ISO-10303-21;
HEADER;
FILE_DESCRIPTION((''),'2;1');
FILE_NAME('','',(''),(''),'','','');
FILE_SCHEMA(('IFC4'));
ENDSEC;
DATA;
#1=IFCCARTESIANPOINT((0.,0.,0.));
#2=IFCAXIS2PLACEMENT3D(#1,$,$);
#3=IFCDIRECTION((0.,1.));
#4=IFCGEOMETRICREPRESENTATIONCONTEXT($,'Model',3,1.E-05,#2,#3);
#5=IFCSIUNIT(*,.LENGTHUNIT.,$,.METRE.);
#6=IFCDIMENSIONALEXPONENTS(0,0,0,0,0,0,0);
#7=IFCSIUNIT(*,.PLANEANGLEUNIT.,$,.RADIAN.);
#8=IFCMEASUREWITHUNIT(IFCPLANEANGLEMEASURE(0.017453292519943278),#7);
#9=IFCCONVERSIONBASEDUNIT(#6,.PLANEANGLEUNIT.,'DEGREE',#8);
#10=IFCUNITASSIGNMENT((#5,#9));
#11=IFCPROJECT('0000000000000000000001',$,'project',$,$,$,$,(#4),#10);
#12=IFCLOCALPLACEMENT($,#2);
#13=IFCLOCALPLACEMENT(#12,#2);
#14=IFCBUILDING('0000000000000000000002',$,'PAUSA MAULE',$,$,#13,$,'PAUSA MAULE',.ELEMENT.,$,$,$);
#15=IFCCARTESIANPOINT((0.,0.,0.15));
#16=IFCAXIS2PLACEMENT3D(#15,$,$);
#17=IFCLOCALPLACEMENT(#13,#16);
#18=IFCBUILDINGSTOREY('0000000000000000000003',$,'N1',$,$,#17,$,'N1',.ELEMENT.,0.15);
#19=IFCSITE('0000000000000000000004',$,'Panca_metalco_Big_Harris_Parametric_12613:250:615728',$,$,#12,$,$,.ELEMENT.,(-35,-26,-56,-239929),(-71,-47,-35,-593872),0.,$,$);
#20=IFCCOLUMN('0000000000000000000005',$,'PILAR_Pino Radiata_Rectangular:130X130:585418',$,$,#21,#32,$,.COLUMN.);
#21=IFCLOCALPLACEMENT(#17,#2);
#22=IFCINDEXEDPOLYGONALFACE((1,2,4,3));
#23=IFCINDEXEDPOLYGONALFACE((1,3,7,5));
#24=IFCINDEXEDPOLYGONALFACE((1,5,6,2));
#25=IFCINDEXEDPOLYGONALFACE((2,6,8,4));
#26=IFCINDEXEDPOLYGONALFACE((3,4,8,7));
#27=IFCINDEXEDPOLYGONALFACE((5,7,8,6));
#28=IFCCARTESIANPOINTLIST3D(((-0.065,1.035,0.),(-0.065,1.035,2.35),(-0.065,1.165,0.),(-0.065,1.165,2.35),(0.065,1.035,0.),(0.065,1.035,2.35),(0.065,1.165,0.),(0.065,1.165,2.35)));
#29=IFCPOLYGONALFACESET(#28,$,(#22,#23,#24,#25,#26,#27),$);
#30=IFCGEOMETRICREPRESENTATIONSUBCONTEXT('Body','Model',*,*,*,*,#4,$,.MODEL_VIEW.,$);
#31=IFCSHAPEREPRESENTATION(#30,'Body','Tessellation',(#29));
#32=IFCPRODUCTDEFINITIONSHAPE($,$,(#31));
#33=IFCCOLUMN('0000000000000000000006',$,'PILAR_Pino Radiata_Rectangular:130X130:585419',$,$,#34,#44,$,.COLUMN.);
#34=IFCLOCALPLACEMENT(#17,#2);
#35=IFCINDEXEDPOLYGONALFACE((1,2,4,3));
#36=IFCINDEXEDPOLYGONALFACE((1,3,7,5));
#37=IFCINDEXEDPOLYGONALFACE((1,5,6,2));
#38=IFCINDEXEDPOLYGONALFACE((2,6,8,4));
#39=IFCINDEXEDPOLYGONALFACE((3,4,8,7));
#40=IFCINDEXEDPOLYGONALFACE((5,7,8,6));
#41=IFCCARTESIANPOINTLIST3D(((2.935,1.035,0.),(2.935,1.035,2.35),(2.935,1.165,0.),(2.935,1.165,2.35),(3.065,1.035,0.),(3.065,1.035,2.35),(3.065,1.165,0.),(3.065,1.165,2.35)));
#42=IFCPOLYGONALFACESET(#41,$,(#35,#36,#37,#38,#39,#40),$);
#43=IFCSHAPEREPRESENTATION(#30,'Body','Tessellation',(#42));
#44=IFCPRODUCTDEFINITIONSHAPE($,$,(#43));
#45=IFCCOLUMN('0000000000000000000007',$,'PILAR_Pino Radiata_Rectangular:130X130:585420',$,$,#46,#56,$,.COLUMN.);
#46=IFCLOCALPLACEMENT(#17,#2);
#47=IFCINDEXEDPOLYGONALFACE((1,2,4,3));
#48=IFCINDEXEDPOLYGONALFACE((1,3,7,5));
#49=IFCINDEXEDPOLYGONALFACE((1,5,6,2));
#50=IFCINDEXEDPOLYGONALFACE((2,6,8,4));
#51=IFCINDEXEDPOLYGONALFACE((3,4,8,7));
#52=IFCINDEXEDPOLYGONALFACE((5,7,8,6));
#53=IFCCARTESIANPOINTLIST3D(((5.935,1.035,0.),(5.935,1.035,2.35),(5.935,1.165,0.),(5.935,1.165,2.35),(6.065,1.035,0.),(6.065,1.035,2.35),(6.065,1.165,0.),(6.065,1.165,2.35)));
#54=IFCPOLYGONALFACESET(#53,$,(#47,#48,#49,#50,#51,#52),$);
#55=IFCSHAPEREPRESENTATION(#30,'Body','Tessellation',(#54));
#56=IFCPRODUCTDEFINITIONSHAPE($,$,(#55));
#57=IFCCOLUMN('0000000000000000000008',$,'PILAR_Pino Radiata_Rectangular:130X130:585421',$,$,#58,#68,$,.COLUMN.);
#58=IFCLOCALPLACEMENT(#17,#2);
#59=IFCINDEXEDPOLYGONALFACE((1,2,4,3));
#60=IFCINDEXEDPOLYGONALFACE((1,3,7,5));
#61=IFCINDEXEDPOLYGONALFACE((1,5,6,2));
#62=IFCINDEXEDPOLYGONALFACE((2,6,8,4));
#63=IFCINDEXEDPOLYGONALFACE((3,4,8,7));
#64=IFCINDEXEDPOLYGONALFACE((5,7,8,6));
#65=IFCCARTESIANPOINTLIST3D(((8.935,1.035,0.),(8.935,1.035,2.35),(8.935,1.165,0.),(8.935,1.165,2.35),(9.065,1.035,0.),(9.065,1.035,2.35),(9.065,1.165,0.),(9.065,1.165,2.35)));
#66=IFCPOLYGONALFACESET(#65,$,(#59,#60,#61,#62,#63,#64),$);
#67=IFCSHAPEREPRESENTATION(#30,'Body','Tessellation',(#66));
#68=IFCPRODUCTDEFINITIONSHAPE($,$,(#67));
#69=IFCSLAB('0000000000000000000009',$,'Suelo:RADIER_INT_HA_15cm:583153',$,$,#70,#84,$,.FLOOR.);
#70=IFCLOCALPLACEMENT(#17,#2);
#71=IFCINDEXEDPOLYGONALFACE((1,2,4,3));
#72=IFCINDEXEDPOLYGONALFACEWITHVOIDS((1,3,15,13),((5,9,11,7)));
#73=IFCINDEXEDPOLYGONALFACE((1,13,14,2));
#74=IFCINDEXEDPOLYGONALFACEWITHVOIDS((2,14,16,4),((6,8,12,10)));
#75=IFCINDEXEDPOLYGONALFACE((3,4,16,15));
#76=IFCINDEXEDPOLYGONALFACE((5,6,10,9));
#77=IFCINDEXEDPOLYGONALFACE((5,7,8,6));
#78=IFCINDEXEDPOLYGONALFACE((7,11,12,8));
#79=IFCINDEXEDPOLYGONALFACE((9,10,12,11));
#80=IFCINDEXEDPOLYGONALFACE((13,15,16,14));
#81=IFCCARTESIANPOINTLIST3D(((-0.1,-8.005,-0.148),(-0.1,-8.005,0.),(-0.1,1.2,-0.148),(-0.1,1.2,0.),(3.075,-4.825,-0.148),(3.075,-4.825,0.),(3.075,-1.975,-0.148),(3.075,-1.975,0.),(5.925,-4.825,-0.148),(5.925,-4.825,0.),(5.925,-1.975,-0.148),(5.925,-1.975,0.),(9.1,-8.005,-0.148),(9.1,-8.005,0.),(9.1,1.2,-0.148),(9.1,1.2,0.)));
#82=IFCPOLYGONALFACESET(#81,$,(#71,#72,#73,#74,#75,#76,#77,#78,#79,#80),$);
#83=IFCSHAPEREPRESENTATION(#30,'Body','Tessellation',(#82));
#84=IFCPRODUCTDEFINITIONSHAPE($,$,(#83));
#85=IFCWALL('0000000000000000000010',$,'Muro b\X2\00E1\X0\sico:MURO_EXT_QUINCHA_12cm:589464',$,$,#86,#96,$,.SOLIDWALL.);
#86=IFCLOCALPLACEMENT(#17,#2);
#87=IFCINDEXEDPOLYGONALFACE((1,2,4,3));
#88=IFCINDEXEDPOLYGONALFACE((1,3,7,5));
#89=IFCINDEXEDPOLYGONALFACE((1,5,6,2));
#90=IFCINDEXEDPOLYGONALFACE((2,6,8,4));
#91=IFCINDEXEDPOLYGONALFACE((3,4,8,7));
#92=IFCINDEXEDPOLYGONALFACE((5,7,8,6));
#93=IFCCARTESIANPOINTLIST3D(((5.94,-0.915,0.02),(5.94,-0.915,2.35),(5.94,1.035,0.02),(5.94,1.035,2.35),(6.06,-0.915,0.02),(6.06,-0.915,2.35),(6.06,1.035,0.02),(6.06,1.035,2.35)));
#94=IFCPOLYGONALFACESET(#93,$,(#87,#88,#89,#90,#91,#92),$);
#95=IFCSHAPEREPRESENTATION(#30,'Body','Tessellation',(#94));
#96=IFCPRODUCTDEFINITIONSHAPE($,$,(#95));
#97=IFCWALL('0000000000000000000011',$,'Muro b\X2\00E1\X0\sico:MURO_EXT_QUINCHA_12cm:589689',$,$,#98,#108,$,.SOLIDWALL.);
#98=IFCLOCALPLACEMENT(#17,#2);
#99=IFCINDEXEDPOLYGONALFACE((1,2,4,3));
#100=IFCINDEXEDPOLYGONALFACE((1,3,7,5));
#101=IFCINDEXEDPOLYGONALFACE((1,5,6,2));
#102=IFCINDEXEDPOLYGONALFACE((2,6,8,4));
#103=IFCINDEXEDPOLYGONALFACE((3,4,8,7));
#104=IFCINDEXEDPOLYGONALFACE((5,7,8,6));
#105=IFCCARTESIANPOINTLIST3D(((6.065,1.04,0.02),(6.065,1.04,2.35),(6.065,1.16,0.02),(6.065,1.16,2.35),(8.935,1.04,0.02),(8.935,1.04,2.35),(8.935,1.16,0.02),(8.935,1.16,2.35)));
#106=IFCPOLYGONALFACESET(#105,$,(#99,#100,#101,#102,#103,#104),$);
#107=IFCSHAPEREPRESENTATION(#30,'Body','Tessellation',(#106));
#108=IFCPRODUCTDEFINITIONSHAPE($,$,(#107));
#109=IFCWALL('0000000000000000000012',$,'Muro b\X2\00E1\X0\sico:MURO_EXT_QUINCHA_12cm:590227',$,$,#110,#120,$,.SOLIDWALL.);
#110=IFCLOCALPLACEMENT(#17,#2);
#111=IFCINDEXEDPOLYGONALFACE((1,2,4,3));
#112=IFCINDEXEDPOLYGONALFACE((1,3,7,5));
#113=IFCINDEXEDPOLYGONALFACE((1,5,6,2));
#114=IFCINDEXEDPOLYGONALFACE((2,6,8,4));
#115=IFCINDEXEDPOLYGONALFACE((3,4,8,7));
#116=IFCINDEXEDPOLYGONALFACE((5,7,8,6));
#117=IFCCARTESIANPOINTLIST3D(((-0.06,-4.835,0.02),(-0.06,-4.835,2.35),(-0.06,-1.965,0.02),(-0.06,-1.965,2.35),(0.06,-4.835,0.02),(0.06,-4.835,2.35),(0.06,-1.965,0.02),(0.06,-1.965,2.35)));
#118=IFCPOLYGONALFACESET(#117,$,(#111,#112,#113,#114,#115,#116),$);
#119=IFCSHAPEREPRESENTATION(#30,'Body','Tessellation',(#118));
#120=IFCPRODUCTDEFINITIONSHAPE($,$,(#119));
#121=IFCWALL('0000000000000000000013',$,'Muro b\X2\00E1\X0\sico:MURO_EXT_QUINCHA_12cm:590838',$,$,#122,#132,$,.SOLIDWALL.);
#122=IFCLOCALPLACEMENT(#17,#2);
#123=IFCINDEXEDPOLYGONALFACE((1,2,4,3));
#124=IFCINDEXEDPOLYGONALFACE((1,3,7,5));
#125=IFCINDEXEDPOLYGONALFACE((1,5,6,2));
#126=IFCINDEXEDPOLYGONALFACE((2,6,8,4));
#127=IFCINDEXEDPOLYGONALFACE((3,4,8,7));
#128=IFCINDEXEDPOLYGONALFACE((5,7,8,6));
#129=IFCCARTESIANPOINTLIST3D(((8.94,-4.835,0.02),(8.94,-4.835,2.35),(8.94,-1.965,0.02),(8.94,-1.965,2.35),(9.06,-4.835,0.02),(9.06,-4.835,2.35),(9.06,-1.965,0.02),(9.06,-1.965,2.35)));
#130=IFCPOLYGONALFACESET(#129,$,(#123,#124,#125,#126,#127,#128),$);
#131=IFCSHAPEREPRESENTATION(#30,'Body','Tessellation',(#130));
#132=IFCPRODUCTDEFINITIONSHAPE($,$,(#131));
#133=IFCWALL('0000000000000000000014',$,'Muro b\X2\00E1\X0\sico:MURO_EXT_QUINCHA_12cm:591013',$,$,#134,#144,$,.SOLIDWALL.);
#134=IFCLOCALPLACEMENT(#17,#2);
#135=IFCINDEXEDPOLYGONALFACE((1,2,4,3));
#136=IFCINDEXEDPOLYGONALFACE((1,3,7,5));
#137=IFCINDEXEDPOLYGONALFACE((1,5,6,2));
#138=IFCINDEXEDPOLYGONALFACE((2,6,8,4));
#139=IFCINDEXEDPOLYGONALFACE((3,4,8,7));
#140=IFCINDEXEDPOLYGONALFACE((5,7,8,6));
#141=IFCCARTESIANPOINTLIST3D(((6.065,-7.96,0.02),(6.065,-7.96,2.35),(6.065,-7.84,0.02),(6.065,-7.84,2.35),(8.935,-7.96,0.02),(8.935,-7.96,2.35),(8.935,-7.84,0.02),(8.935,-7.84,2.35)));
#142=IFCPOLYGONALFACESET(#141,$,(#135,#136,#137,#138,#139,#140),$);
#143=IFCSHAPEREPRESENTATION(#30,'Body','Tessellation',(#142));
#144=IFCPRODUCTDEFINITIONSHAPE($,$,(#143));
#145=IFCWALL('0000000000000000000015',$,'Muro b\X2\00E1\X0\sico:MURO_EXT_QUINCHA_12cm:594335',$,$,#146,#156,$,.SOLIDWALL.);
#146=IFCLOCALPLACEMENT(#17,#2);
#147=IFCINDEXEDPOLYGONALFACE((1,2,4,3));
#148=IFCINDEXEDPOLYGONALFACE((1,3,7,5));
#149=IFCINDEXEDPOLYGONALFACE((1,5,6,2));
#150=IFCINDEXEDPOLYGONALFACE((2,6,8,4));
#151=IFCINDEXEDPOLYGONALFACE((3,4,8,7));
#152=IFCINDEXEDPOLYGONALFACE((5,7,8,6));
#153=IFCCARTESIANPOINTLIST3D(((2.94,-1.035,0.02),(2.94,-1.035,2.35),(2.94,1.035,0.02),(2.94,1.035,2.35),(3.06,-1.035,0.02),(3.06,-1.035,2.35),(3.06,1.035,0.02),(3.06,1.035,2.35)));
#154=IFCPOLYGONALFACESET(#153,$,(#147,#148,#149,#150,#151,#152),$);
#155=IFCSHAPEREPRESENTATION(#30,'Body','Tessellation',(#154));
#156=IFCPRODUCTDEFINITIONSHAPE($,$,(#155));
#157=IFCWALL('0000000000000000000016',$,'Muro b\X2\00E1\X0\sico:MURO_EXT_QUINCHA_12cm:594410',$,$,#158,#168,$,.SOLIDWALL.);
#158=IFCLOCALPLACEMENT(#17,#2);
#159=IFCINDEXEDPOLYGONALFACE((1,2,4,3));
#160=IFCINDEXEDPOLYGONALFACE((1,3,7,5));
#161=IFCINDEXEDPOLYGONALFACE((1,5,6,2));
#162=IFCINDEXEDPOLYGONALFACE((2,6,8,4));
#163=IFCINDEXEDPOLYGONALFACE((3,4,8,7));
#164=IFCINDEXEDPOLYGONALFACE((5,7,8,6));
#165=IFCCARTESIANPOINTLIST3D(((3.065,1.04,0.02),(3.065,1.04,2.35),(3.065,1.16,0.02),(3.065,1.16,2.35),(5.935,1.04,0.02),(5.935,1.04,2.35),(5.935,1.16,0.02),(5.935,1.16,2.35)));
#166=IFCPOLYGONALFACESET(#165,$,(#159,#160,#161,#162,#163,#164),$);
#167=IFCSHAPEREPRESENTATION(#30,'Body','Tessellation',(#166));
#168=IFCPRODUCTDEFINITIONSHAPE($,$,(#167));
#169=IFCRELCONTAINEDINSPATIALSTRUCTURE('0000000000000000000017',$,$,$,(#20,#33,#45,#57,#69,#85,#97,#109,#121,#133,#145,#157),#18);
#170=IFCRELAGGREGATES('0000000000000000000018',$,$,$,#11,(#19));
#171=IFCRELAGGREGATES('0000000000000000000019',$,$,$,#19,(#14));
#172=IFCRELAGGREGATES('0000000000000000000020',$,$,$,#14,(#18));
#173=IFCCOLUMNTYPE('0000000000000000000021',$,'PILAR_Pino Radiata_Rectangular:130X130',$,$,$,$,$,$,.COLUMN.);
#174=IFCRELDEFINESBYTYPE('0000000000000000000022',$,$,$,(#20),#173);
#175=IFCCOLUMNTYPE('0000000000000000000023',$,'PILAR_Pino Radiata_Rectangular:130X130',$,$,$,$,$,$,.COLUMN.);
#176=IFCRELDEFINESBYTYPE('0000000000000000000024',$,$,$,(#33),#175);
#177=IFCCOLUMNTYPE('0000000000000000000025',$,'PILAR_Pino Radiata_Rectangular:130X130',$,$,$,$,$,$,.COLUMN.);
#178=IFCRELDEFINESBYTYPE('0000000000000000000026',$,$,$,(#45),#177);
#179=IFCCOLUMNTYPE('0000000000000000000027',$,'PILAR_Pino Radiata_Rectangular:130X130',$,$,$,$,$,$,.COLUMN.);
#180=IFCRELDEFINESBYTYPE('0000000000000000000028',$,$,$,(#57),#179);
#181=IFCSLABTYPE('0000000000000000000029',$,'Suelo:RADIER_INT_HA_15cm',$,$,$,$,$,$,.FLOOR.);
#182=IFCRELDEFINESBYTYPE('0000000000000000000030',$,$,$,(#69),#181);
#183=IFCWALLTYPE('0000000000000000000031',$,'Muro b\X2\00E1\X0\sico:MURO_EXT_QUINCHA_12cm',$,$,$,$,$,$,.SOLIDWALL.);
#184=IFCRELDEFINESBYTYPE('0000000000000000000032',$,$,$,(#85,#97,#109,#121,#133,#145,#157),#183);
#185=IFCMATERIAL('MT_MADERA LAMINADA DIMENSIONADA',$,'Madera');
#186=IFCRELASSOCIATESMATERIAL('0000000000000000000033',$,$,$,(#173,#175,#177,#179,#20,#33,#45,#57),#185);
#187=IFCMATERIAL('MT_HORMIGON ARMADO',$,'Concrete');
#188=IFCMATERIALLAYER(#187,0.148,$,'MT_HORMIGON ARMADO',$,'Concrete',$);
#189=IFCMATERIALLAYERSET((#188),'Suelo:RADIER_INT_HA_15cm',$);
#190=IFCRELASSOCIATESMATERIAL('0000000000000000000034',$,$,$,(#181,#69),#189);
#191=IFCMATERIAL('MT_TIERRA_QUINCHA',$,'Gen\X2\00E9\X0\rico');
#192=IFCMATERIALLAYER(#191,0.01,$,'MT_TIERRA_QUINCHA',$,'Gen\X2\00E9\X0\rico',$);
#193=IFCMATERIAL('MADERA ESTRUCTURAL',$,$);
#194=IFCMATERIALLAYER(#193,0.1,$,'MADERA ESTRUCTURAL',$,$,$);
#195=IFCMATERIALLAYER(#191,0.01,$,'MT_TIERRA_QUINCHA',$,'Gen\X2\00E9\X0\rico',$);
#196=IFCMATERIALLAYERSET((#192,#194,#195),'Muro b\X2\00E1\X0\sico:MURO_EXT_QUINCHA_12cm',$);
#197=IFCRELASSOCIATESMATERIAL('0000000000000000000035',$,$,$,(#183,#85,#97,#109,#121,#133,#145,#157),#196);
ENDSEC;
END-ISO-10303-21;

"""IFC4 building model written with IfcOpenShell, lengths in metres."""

from ifc_helpers import new_model, entity, si_unit, converted_unit, direction, frame, frame_2d, origin, origin_2d_with_axis, place, context, subcontext, project, spatial, rectangle, extrude, boolean, source, transform, mapped, material, layer, layer_set, layer_usage, material_profile, profile_set, profile_usage, type_object, type_shapes, element, save


model = new_model("IFC4")

# Units and contexts
model_context = context("Model", 3, precision=1e-05, world=origin(), true_north=direction((0.0, 1.0)))
body_context = subcontext(model_context, "Body", "Model", "MODEL_VIEW")
ifc_project = project(units=[si_unit("LENGTHUNIT", "METRE"), converted_unit("PLANEANGLEUNIT", "DEGREE", entity("IfcPlaneAngleMeasure", 0.017453292519943278), si_unit("PLANEANGLEUNIT", "RADIAN"), dimensions=[0, 0, 0, 0, 0, 0, 0])], contexts=[model_context])

# Site, building, storey
site_placement = place(None, origin())
site = spatial("IfcSite", under=ifc_project, at=site_placement, Name="Panca_metalco_Big_Harris_Parametric_12613:250:615728", CompositionType="ELEMENT", RefLatitude=(-35, -26, -56, -239929), RefLongitude=(-71, -47, -35, -593872), RefElevation=0.0)
building_placement = place(site_placement, origin())
building = spatial("IfcBuilding", under=site, at=building_placement, Name="PAUSA MAULE", LongName="PAUSA MAULE", CompositionType="ELEMENT")
storey_placement = place(building_placement, frame((0.0, 0.0, 0.15)))
storey = spatial("IfcBuildingStorey", under=building, at=storey_placement, Name="N1", LongName="N1", CompositionType="ELEMENT", Elevation=0.15)

# Columns
ifc_material_1 = material(Name="MT_MADERA LAMINADA DIMENSIONADA", Category="Madera")
ifc_material_profile = material_profile(ifc_material_1, rectangle(XDim=0.13, YDim=0.13, at=frame_2d((0.0, 0.0), x_axis=(1.0, 0.0))), Name="130X130")
ifc_profile_set = profile_set([ifc_material_profile], Name="130X130")
ifc_profile_usage = profile_usage(ifc_profile_set)
column_type_1 = type_object("IfcColumnType", Name="PILAR_Pino Radiata_Rectangular:130X130", PredefinedType="COLUMN", material=ifc_profile_set)
shared_shape_1 = source(origin(), body_context, "Body", "SweptSolid", [
    extrude(rectangle(XDim=0.13, YDim=0.13, at=origin_2d_with_axis()), frame((0.0, 1.1, 0.15)), (0.0, 0.0, 1.0), 2.35),
])
type_shapes(column_type_1, [shared_shape_1])
column_1_placement = place(storey_placement, frame((0.0, 0.0, -0.15)))
element("IfcColumn", 1, at=column_1_placement, inside=storey, type_object=column_type_1, material=ifc_profile_usage, Name="PILAR_Pino Radiata_Rectangular:130X130:585418", PredefinedType="COLUMN", context=body_context, shape_type="MappedRepresentation", body=[
    mapped(shared_shape_1, transform((0.0, 0.0, 0.0), scale=1.0)),
])
column_type_2 = type_object("IfcColumnType", Name="PILAR_Pino Radiata_Rectangular:130X130", PredefinedType="COLUMN", material=ifc_profile_set)
shared_shape_2 = source(origin(), body_context, "Body", "SweptSolid", [
    extrude(rectangle(XDim=0.13, YDim=0.13, at=origin_2d_with_axis()), frame((3.0, 1.1, 0.15)), (0.0, 0.0, 1.0), 2.35),
])
type_shapes(column_type_2, [shared_shape_2])
column_2_placement = place(storey_placement, frame((0.0, 0.0, -0.15)))
element("IfcColumn", 2, at=column_2_placement, inside=storey, type_object=column_type_2, material=ifc_profile_usage, Name="PILAR_Pino Radiata_Rectangular:130X130:585419", PredefinedType="COLUMN", context=body_context, shape_type="MappedRepresentation", body=[
    mapped(shared_shape_2, transform((0.0, 0.0, 0.0), scale=1.0)),
])
column_type_3 = type_object("IfcColumnType", Name="PILAR_Pino Radiata_Rectangular:130X130", PredefinedType="COLUMN", material=ifc_profile_set)
shared_shape_3 = source(origin(), body_context, "Body", "SweptSolid", [
    extrude(rectangle(XDim=0.13, YDim=0.13, at=frame_2d((0.0, 0.0), x_axis=(1.0, 0.0))), frame((6.0, 1.1, 0.15)), (0.0, 0.0, 1.0), 2.35),
])
type_shapes(column_type_3, [shared_shape_3])
column_3_placement = place(storey_placement, frame((0.0, 0.0, -0.15)))
element("IfcColumn", 3, at=column_3_placement, inside=storey, type_object=column_type_3, material=ifc_profile_usage, Name="PILAR_Pino Radiata_Rectangular:130X130:585420", PredefinedType="COLUMN", context=body_context, shape_type="MappedRepresentation", body=[
    mapped(shared_shape_3, transform((0.0, 0.0, 0.0), scale=1.0)),
])
column_type_4 = type_object("IfcColumnType", Name="PILAR_Pino Radiata_Rectangular:130X130", PredefinedType="COLUMN", material=ifc_profile_set)
shared_shape_4 = source(origin(), body_context, "Body", "SweptSolid", [
    extrude(rectangle(XDim=0.13, YDim=0.13, at=frame_2d((0.0, 0.0), x_axis=(1.0, 0.0))), frame((9.0, 1.1, 0.15)), (0.0, 0.0, 1.0), 2.35),
])
type_shapes(column_type_4, [shared_shape_4])
column_4_placement = place(storey_placement, frame((0.0, 0.0, -0.15)))
element("IfcColumn", 4, at=column_4_placement, inside=storey, type_object=column_type_4, material=ifc_profile_usage, Name="PILAR_Pino Radiata_Rectangular:130X130:585421", PredefinedType="COLUMN", context=body_context, shape_type="MappedRepresentation", body=[
    mapped(shared_shape_4, transform((0.0, 0.0, 0.0), scale=1.0)),
])

# Slab, opening
ifc_material_2 = material(Name="MT_HORMIGON ARMADO", Category="Concrete")
ifc_layer_1 = layer(ifc_material_2, 0.148, Name="MT_HORMIGON ARMADO", Category="Concrete")
ifc_layer_set_1 = layer_set([ifc_layer_1], Name="Suelo:RADIER_INT_HA_15cm")
ifc_layer_usage_1 = layer_usage(ifc_layer_set_1, "AXIS3", "POSITIVE", 0.0)
slab_type = type_object("IfcSlabType", Name="Suelo:RADIER_INT_HA_15cm", PredefinedType="FLOOR", material=ifc_layer_set_1)
slab_placement = place(storey_placement, origin())
slab = element("IfcSlab", 5, at=slab_placement, inside=storey, type_object=slab_type, material=ifc_layer_usage_1, Name="Suelo:RADIER_INT_HA_15cm:583153", PredefinedType="FLOOR", context=body_context, shape_type="CSG", body=[
    boolean("DIFFERENCE", extrude(rectangle(XDim=9.205, YDim=9.2, at=frame_2d((0.0, 0.0), x_axis=(1.0, 0.0))), frame((4.5, -3.4025, 0.0), z_axis=(0.0, 0.0, -1.0), x_axis=(0.0, 1.0, 0.0)), (0.0, 0.0, 1.0), 0.148), extrude(rectangle(XDim=2.85, YDim=2.85, at=origin_2d_with_axis()), frame((4.5, -3.4, -0.148), z_axis=(0.0, 0.0, 1.0), x_axis=(0.0, 1.0, 0.0)), (0.0, 0.0, 1.0), 0.148)),
])
opening_1_placement = place(slab_placement, origin())
element("IfcOpeningElement", 6, at=opening_1_placement, cuts=slab, PredefinedType="OPENING", context=body_context, shape_type="SweptSolid", body=[
    extrude(rectangle(XDim=2.85, YDim=2.85, at=frame_2d((4.5, -3.4), x_axis=(0.0, -1.0))), origin(), (0.0, 0.0, -1.0), 0.148),
])

# Walls
ifc_material_3 = material(Name="MT_TIERRA_QUINCHA", Category="Genérico")
ifc_layer_2 = layer(ifc_material_3, 0.01, Name="MT_TIERRA_QUINCHA", Category="Genérico")
ifc_material_4 = material(Name="MADERA ESTRUCTURAL")
ifc_layer_3 = layer(ifc_material_4, 0.1, Name="MADERA ESTRUCTURAL")
ifc_layer_4 = layer(ifc_material_3, 0.01, Name="MT_TIERRA_QUINCHA", Category="Genérico")
ifc_layer_set_2 = layer_set([ifc_layer_2, ifc_layer_3, ifc_layer_4], Name="Muro básico:MURO_EXT_QUINCHA_12cm")
ifc_layer_usage_2 = layer_usage(ifc_layer_set_2, "AXIS2", "NEGATIVE", 0.06)
wall_type = type_object("IfcWallType", Name="Muro básico:MURO_EXT_QUINCHA_12cm", PredefinedType="SOLIDWALL", material=ifc_layer_set_2)
wall_1_placement = place(storey_placement, frame((6.0, -0.915, 0.02), z_axis=(0.0, 0.0, 1.0), x_axis=(0.0, 1.0, 0.0)))
element("IfcWall", 7, at=wall_1_placement, inside=storey, type_object=wall_type, material=ifc_layer_usage_2, Name="Muro básico:MURO_EXT_QUINCHA_12cm:589464", PredefinedType="SOLIDWALL", context=body_context, shape_type="SweptSolid", body=[
    extrude(rectangle(XDim=1.95, YDim=0.12, at=frame_2d((0.975, 0.0), x_axis=(-1.0, 0.0))), origin(), (0.0, 0.0, 1.0), 2.33),
])
ifc_layer_usage_3 = layer_usage(ifc_layer_set_2, "AXIS2", "NEGATIVE", 0.06)
wall_2_placement = place(storey_placement, frame((6.065, 1.1, 0.02)))
element("IfcWall", 8, at=wall_2_placement, inside=storey, type_object=wall_type, material=ifc_layer_usage_3, Name="Muro básico:MURO_EXT_QUINCHA_12cm:589689", PredefinedType="SOLIDWALL", context=body_context, shape_type="SweptSolid", body=[
    extrude(rectangle(XDim=2.87, YDim=0.12, at=frame_2d((1.435, 0.0), x_axis=(-1.0, 0.0))), origin(), (0.0, 0.0, 1.0), 2.33),
])
ifc_layer_usage_4 = layer_usage(ifc_layer_set_2, "AXIS2", "NEGATIVE", 0.06)
wall_3_placement = place(storey_placement, frame((0.0, -1.965, 0.02), z_axis=(0.0, 0.0, 1.0), x_axis=(0.0, -1.0, 0.0)))
element("IfcWall", 9, at=wall_3_placement, inside=storey, type_object=wall_type, material=ifc_layer_usage_4, Name="Muro básico:MURO_EXT_QUINCHA_12cm:590227", PredefinedType="SOLIDWALL", context=body_context, shape_type="SweptSolid", body=[
    extrude(rectangle(XDim=2.87, YDim=0.12, at=frame_2d((1.435, 0.0), x_axis=(-1.0, 0.0))), origin(), (0.0, 0.0, 1.0), 2.33),
])
ifc_layer_usage_5 = layer_usage(ifc_layer_set_2, "AXIS2", "NEGATIVE", 0.06)
wall_4_placement = place(storey_placement, frame((9.0, -1.965, 0.02), z_axis=(0.0, 0.0, 1.0), x_axis=(0.0, -1.0, 0.0)))
element("IfcWall", 10, at=wall_4_placement, inside=storey, type_object=wall_type, material=ifc_layer_usage_5, Name="Muro básico:MURO_EXT_QUINCHA_12cm:590838", PredefinedType="SOLIDWALL", context=body_context, shape_type="SweptSolid", body=[
    extrude(rectangle(XDim=2.87, YDim=0.12, at=frame_2d((1.435, 0.0), x_axis=(-1.0, 0.0))), origin(), (0.0, 0.0, 1.0), 2.33),
])
ifc_layer_usage_6 = layer_usage(ifc_layer_set_2, "AXIS2", "NEGATIVE", 0.06)
wall_5_placement = place(storey_placement, frame((8.935, -7.9, 0.02), z_axis=(0.0, 0.0, 1.0), x_axis=(-1.0, 0.0, 0.0)))
element("IfcWall", 11, at=wall_5_placement, inside=storey, type_object=wall_type, material=ifc_layer_usage_6, Name="Muro básico:MURO_EXT_QUINCHA_12cm:591013", PredefinedType="SOLIDWALL", context=body_context, shape_type="SweptSolid", body=[
    extrude(rectangle(XDim=2.87, YDim=0.12, at=frame_2d((1.435, 0.0), x_axis=(-1.0, 0.0))), origin(), (0.0, 0.0, 1.0), 2.33),
])
ifc_layer_usage_7 = layer_usage(ifc_layer_set_2, "AXIS2", "NEGATIVE", 0.06)
wall_6_placement = place(storey_placement, frame((3.0, 1.035, 0.02), z_axis=(0.0, 0.0, 1.0), x_axis=(0.0, -1.0, 0.0)))
element("IfcWall", 12, at=wall_6_placement, inside=storey, type_object=wall_type, material=ifc_layer_usage_7, Name="Muro básico:MURO_EXT_QUINCHA_12cm:594335", PredefinedType="SOLIDWALL", context=body_context, shape_type="SweptSolid", body=[
    extrude(rectangle(XDim=2.07, YDim=0.12, at=frame_2d((1.035, 0.0), x_axis=(-1.0, 0.0))), origin(), (0.0, 0.0, 1.0), 2.33),
])
ifc_layer_usage_8 = layer_usage(ifc_layer_set_2, "AXIS2", "NEGATIVE", 0.06)
wall_7_placement = place(storey_placement, frame((3.065, 1.1, 0.02)))
element("IfcWall", 13, at=wall_7_placement, inside=storey, type_object=wall_type, material=ifc_layer_usage_8, Name="Muro básico:MURO_EXT_QUINCHA_12cm:594410", PredefinedType="SOLIDWALL", context=body_context, shape_type="SweptSolid", body=[
    extrude(rectangle(XDim=2.87, YDim=0.12, at=frame_2d((1.435, 0.0), x_axis=(-1.0, 0.0))), origin(), (0.0, 0.0, 1.0), 2.33),
])

save(model, "model.ifc")
